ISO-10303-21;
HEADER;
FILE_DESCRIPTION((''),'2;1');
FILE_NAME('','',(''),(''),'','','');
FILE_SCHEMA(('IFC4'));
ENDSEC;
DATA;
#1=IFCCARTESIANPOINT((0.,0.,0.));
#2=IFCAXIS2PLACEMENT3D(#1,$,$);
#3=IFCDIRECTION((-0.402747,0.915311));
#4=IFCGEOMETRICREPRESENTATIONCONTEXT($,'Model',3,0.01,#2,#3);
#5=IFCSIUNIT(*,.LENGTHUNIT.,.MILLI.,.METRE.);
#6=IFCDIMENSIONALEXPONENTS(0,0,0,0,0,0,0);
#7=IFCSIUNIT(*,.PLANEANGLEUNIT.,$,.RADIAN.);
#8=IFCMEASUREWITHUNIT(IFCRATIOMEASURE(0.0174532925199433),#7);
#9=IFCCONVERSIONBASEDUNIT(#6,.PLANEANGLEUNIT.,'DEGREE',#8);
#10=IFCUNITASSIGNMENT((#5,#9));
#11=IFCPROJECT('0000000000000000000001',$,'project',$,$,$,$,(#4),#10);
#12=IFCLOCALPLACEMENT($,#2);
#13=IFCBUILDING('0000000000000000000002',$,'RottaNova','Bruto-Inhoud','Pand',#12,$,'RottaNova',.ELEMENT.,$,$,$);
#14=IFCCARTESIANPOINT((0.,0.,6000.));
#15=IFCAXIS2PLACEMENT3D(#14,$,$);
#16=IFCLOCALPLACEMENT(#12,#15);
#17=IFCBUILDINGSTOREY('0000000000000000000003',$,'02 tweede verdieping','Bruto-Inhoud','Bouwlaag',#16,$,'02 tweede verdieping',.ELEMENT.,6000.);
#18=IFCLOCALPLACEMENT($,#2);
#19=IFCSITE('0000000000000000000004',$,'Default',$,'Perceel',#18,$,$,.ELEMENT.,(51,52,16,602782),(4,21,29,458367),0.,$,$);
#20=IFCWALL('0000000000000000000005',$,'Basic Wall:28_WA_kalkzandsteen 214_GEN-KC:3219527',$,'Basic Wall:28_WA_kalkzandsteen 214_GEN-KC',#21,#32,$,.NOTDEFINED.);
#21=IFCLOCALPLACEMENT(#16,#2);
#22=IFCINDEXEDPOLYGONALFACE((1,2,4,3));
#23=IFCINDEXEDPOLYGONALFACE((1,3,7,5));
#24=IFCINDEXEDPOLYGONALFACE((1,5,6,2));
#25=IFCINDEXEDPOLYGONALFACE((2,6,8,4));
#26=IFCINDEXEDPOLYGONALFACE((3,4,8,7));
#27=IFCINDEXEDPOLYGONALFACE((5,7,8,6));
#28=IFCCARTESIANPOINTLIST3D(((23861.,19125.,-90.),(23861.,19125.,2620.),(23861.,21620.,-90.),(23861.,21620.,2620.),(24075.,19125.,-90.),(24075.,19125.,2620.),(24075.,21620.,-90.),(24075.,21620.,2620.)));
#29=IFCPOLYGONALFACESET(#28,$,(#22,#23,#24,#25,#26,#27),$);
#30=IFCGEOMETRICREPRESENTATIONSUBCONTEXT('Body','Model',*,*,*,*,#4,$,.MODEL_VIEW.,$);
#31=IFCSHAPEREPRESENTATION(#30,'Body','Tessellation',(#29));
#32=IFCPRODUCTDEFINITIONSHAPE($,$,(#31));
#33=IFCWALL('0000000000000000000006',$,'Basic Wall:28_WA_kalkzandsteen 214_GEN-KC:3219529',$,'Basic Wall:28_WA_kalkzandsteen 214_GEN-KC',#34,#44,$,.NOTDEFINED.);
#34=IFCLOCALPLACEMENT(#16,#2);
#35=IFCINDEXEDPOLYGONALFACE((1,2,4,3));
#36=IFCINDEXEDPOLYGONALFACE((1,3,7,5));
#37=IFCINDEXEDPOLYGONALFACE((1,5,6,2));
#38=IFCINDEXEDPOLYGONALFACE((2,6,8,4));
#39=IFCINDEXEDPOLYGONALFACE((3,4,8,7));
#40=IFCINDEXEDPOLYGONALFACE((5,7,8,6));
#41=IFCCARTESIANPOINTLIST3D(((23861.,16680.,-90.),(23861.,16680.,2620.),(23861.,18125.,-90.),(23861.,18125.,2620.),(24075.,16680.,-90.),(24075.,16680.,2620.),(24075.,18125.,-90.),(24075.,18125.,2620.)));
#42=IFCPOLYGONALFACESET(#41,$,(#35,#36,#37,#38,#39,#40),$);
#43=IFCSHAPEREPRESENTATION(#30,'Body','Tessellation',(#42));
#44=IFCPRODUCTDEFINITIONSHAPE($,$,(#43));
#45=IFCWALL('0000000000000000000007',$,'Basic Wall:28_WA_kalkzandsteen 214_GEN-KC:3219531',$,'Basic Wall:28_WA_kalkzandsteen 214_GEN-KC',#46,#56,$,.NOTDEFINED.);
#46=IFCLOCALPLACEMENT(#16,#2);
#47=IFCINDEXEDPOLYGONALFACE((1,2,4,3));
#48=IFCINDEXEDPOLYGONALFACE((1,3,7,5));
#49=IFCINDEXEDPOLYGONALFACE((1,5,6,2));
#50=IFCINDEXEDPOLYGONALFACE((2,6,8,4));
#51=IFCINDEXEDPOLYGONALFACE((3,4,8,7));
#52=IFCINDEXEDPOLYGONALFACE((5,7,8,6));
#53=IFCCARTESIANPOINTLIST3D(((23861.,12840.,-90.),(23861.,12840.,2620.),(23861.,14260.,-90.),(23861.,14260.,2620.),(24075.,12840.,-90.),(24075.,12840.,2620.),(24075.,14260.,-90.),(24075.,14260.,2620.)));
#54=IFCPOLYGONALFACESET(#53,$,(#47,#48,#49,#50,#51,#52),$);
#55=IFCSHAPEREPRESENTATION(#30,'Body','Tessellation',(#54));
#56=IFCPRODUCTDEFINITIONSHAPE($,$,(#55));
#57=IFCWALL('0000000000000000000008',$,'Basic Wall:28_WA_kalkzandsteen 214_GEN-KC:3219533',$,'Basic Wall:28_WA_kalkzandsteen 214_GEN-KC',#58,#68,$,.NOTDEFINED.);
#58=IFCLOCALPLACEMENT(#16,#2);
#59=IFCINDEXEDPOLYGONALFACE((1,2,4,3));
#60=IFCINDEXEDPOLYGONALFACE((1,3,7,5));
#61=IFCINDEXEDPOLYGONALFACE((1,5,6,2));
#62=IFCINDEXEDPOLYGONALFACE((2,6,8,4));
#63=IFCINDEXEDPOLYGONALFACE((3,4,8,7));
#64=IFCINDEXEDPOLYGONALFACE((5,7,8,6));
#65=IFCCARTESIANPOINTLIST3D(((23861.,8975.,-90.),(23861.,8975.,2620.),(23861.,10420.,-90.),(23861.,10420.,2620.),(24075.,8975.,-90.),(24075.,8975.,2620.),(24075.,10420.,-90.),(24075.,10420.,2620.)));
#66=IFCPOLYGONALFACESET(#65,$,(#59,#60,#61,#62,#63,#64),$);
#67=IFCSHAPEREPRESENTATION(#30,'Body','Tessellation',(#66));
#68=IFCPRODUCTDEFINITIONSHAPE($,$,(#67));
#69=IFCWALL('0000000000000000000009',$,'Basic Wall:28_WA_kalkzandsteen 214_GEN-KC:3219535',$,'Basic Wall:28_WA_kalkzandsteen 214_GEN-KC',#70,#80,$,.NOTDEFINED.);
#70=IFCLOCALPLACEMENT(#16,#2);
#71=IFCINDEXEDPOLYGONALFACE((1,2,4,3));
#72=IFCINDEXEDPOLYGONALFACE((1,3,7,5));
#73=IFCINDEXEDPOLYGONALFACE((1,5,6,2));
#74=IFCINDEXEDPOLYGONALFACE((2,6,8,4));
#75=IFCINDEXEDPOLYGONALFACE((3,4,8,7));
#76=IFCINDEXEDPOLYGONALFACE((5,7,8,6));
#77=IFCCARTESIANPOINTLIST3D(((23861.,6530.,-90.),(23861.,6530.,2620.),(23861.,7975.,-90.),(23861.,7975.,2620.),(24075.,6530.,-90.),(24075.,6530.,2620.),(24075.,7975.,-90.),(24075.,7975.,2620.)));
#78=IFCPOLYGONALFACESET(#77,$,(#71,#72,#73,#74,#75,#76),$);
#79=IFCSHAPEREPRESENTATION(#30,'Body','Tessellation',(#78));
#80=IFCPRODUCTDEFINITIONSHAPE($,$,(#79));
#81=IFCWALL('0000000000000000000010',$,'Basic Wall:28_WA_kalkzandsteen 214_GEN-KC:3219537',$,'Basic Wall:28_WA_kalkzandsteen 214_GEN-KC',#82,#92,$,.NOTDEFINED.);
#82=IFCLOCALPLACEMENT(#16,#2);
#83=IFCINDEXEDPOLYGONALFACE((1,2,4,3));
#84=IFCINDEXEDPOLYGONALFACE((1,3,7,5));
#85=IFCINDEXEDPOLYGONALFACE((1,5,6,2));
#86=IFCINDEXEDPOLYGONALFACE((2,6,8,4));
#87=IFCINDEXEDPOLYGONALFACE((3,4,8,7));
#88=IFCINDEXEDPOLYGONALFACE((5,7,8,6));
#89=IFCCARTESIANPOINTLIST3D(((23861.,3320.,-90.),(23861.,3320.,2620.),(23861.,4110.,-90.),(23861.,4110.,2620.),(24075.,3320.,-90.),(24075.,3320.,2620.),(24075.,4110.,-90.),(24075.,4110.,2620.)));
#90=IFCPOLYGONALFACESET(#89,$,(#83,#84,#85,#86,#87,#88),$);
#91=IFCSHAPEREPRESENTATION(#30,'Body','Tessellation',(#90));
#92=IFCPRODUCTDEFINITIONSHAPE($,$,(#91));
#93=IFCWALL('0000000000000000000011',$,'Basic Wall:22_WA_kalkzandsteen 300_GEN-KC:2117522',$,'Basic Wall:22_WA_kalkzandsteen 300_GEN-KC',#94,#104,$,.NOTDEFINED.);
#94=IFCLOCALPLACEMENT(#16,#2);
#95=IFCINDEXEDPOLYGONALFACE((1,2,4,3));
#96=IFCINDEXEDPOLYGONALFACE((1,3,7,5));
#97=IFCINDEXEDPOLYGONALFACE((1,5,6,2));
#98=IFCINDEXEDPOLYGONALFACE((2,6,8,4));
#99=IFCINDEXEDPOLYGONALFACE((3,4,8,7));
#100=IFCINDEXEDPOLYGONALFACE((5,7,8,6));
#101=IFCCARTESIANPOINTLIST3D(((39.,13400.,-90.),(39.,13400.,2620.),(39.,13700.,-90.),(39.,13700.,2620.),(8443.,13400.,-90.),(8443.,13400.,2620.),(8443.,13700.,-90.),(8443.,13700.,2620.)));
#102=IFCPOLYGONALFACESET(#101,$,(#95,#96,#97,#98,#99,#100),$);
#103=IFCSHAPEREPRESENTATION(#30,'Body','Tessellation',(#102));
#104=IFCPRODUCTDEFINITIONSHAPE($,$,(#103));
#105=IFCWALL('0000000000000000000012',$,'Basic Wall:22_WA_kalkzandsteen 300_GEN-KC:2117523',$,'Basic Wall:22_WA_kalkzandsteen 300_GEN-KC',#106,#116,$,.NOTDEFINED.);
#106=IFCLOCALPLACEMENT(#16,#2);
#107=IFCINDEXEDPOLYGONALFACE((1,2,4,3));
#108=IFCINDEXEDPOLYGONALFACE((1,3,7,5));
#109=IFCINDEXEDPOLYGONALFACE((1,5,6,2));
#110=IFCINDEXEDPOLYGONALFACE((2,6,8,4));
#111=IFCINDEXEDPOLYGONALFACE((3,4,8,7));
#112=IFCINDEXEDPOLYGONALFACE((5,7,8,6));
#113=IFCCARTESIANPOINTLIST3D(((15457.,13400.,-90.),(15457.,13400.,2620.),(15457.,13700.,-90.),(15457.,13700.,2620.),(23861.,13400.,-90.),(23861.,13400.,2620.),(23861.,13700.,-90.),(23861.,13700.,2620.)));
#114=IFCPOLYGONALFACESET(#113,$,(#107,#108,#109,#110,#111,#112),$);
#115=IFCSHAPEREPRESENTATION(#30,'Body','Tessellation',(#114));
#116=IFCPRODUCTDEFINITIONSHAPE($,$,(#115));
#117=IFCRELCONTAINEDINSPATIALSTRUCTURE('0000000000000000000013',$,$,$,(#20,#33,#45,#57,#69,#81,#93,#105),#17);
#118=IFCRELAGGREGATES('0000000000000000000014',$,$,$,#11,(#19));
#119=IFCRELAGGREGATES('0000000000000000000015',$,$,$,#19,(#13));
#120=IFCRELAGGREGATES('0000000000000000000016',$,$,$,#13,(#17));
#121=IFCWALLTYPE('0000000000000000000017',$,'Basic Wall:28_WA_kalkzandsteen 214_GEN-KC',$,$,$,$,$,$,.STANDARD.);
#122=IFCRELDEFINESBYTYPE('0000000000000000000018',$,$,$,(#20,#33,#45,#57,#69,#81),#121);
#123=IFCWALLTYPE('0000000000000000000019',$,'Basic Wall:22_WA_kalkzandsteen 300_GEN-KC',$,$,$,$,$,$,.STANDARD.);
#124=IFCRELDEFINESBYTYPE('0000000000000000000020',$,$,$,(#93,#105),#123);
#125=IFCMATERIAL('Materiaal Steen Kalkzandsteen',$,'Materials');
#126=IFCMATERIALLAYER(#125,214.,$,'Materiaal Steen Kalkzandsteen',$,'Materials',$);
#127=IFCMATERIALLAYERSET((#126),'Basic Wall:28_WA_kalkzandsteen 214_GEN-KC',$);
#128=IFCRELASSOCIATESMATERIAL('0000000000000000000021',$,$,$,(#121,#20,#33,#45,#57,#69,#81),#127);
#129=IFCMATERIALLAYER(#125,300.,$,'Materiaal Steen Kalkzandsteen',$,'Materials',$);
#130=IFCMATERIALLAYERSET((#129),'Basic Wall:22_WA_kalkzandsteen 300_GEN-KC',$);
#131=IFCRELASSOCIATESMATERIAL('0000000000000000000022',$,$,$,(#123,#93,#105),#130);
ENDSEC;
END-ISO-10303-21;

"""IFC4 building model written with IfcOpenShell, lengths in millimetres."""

from ifc_helpers import new_model, entity, si_unit, converted_unit, direction, frame, frame_2d, origin, place, context, subcontext, project, spatial, rectangle, extrude, material, layer, layer_set, type_object, element, save


model = new_model("IFC4")

# Units and contexts
model_context = context("Model", 3, precision=0.01, world=origin(), true_north=direction((-0.402747, 0.915311)))
body_context = subcontext(model_context, "Body", "Model", "MODEL_VIEW")
ifc_project = project(units=[si_unit("LENGTHUNIT", "METRE", prefix="MILLI"), converted_unit("PLANEANGLEUNIT", "DEGREE", entity("IfcRatioMeasure", 0.0174532925199433), si_unit("PLANEANGLEUNIT", "RADIAN"), dimensions=[0, 0, 0, 0, 0, 0, 0])], contexts=[model_context])

# Site, building, storey
site_placement = place(None, origin())
site = spatial("IfcSite", under=ifc_project, at=site_placement, Name="Default", ObjectType="Perceel", CompositionType="ELEMENT", RefLatitude=(51, 52, 16, 602782), RefLongitude=(4, 21, 29, 458367), RefElevation=0.0)
building_placement = place(None, origin())
building = spatial("IfcBuilding", under=site, at=building_placement, Name="RottaNova", Description="Bruto-Inhoud", ObjectType="Pand", LongName="RottaNova", CompositionType="ELEMENT")
storey_placement = place(building_placement, frame((0.0, 0.0, 6000.0)))
storey = spatial("IfcBuildingStorey", under=building, at=storey_placement, Name="02 tweede verdieping", Description="Bruto-Inhoud", ObjectType="Bouwlaag", LongName="02 tweede verdieping", CompositionType="ELEMENT", Elevation=6000.0)

# Walls
ifc_material_1 = material(Name="Materiaal Steen Kalkzandsteen", Category="Materials")
ifc_layer_1 = layer(ifc_material_1, 214.0, Name="Materiaal Steen Kalkzandsteen", Category="Materials")
ifc_layer_set_1 = layer_set([ifc_layer_1], Name="Basic Wall:28_WA_kalkzandsteen 214_GEN-KC")
wall_type_1 = type_object("IfcWallType", Name="Basic Wall:28_WA_kalkzandsteen 214_GEN-KC", PredefinedType="STANDARD", material=ifc_layer_set_1)
wall_1_placement = place(storey_placement, frame((23968.0, 21620.0, -90.0), z_axis=(0.0, 0.0, 1.0), x_axis=(0.0, -1.0, 0.0)))
element("IfcWall", 1, at=wall_1_placement, inside=storey, type_object=wall_type_1, material=ifc_layer_set_1, Name="Basic Wall:28_WA_kalkzandsteen 214_GEN-KC:3219527", ObjectType="Basic Wall:28_WA_kalkzandsteen 214_GEN-KC", PredefinedType="NOTDEFINED", context=body_context, shape_type="SweptSolid", body=[
    extrude(rectangle(XDim=2495.0, YDim=214.0, at=frame_2d((1247.5, 0.0), x_axis=(-1.0, 0.0))), origin(), (0.0, 0.0, 1.0), 2710.0),
])
wall_2_placement = place(storey_placement, frame((23968.0, 18125.0, -90.0), z_axis=(0.0, 0.0, 1.0), x_axis=(0.0, -1.0, 0.0)))
element("IfcWall", 2, at=wall_2_placement, inside=storey, type_object=wall_type_1, material=ifc_layer_set_1, Name="Basic Wall:28_WA_kalkzandsteen 214_GEN-KC:3219529", ObjectType="Basic Wall:28_WA_kalkzandsteen 214_GEN-KC", PredefinedType="NOTDEFINED", context=body_context, shape_type="SweptSolid", body=[
    extrude(rectangle(XDim=1445.0, YDim=214.0, at=frame_2d((722.5, 0.0), x_axis=(-1.0, 0.0))), origin(), (0.0, 0.0, 1.0), 2710.0),
])
wall_3_placement = place(storey_placement, frame((23968.0, 14260.0, -90.0), z_axis=(0.0, 0.0, 1.0), x_axis=(0.0, -1.0, 0.0)))
element("IfcWall", 3, at=wall_3_placement, inside=storey, type_object=wall_type_1, material=ifc_layer_set_1, Name="Basic Wall:28_WA_kalkzandsteen 214_GEN-KC:3219531", ObjectType="Basic Wall:28_WA_kalkzandsteen 214_GEN-KC", PredefinedType="NOTDEFINED", context=body_context, shape_type="SweptSolid", body=[
    extrude(rectangle(XDim=1420.0, YDim=214.0, at=frame_2d((710.0, 0.0), x_axis=(-1.0, 0.0))), origin(), (0.0, 0.0, 1.0), 2710.0),
])
wall_4_placement = place(storey_placement, frame((23968.0, 10420.0, -90.0), z_axis=(0.0, 0.0, 1.0), x_axis=(0.0, -1.0, 0.0)))
element("IfcWall", 4, at=wall_4_placement, inside=storey, type_object=wall_type_1, material=ifc_layer_set_1, Name="Basic Wall:28_WA_kalkzandsteen 214_GEN-KC:3219533", ObjectType="Basic Wall:28_WA_kalkzandsteen 214_GEN-KC", PredefinedType="NOTDEFINED", context=body_context, shape_type="SweptSolid", body=[
    extrude(rectangle(XDim=1445.0, YDim=214.0, at=frame_2d((722.5, 0.0), x_axis=(-1.0, 0.0))), origin(), (0.0, 0.0, 1.0), 2710.0),
])
wall_5_placement = place(storey_placement, frame((23968.0, 7975.0, -90.0), z_axis=(0.0, 0.0, 1.0), x_axis=(0.0, -1.0, 0.0)))
element("IfcWall", 5, at=wall_5_placement, inside=storey, type_object=wall_type_1, material=ifc_layer_set_1, Name="Basic Wall:28_WA_kalkzandsteen 214_GEN-KC:3219535", ObjectType="Basic Wall:28_WA_kalkzandsteen 214_GEN-KC", PredefinedType="NOTDEFINED", context=body_context, shape_type="SweptSolid", body=[
    extrude(rectangle(XDim=1445.0, YDim=214.0, at=frame_2d((722.5, 0.0), x_axis=(-1.0, 0.0))), origin(), (0.0, 0.0, 1.0), 2710.0),
])
wall_6_placement = place(storey_placement, frame((23968.0, 4110.0, -90.0), z_axis=(0.0, 0.0, 1.0), x_axis=(0.0, -1.0, 0.0)))
element("IfcWall", 6, at=wall_6_placement, inside=storey, type_object=wall_type_1, material=ifc_layer_set_1, Name="Basic Wall:28_WA_kalkzandsteen 214_GEN-KC:3219537", ObjectType="Basic Wall:28_WA_kalkzandsteen 214_GEN-KC", PredefinedType="NOTDEFINED", context=body_context, shape_type="SweptSolid", body=[
    extrude(rectangle(XDim=790.0, YDim=214.0, at=frame_2d((395.0, 0.0), x_axis=(-1.0, 0.0))), origin(), (0.0, 0.0, 1.0), 2710.0),
])
ifc_layer_2 = layer(ifc_material_1, 300.0, Name="Materiaal Steen Kalkzandsteen", Category="Materials")
ifc_layer_set_2 = layer_set([ifc_layer_2], Name="Basic Wall:22_WA_kalkzandsteen 300_GEN-KC")
wall_type_2 = type_object("IfcWallType", Name="Basic Wall:22_WA_kalkzandsteen 300_GEN-KC", PredefinedType="STANDARD", material=ifc_layer_set_2)
wall_7_placement = place(storey_placement, frame((39.0, 13550.0, -90.0)))
element("IfcWall", 7, at=wall_7_placement, inside=storey, type_object=wall_type_2, material=ifc_layer_set_2, Name="Basic Wall:22_WA_kalkzandsteen 300_GEN-KC:2117522", ObjectType="Basic Wall:22_WA_kalkzandsteen 300_GEN-KC", PredefinedType="NOTDEFINED", context=body_context, shape_type="SweptSolid", body=[
    extrude(rectangle(XDim=8404.0, YDim=300.0, at=frame_2d((4202.0, 0.0), x_axis=(-1.0, 0.0))), origin(), (0.0, 0.0, 1.0), 2710.0),
])
wall_8_placement = place(storey_placement, frame((15457.0, 13550.0, -90.0)))
element("IfcWall", 8, at=wall_8_placement, inside=storey, type_object=wall_type_2, material=ifc_layer_set_2, Name="Basic Wall:22_WA_kalkzandsteen 300_GEN-KC:2117523", ObjectType="Basic Wall:22_WA_kalkzandsteen 300_GEN-KC", PredefinedType="NOTDEFINED", context=body_context, shape_type="SweptSolid", body=[
    extrude(rectangle(XDim=8404.0, YDim=300.0, at=frame_2d((4202.0, 0.0), x_axis=(-1.0, 0.0))), origin(), (0.0, 0.0, 1.0), 2710.0),
])

save(model, "model.ifc")
